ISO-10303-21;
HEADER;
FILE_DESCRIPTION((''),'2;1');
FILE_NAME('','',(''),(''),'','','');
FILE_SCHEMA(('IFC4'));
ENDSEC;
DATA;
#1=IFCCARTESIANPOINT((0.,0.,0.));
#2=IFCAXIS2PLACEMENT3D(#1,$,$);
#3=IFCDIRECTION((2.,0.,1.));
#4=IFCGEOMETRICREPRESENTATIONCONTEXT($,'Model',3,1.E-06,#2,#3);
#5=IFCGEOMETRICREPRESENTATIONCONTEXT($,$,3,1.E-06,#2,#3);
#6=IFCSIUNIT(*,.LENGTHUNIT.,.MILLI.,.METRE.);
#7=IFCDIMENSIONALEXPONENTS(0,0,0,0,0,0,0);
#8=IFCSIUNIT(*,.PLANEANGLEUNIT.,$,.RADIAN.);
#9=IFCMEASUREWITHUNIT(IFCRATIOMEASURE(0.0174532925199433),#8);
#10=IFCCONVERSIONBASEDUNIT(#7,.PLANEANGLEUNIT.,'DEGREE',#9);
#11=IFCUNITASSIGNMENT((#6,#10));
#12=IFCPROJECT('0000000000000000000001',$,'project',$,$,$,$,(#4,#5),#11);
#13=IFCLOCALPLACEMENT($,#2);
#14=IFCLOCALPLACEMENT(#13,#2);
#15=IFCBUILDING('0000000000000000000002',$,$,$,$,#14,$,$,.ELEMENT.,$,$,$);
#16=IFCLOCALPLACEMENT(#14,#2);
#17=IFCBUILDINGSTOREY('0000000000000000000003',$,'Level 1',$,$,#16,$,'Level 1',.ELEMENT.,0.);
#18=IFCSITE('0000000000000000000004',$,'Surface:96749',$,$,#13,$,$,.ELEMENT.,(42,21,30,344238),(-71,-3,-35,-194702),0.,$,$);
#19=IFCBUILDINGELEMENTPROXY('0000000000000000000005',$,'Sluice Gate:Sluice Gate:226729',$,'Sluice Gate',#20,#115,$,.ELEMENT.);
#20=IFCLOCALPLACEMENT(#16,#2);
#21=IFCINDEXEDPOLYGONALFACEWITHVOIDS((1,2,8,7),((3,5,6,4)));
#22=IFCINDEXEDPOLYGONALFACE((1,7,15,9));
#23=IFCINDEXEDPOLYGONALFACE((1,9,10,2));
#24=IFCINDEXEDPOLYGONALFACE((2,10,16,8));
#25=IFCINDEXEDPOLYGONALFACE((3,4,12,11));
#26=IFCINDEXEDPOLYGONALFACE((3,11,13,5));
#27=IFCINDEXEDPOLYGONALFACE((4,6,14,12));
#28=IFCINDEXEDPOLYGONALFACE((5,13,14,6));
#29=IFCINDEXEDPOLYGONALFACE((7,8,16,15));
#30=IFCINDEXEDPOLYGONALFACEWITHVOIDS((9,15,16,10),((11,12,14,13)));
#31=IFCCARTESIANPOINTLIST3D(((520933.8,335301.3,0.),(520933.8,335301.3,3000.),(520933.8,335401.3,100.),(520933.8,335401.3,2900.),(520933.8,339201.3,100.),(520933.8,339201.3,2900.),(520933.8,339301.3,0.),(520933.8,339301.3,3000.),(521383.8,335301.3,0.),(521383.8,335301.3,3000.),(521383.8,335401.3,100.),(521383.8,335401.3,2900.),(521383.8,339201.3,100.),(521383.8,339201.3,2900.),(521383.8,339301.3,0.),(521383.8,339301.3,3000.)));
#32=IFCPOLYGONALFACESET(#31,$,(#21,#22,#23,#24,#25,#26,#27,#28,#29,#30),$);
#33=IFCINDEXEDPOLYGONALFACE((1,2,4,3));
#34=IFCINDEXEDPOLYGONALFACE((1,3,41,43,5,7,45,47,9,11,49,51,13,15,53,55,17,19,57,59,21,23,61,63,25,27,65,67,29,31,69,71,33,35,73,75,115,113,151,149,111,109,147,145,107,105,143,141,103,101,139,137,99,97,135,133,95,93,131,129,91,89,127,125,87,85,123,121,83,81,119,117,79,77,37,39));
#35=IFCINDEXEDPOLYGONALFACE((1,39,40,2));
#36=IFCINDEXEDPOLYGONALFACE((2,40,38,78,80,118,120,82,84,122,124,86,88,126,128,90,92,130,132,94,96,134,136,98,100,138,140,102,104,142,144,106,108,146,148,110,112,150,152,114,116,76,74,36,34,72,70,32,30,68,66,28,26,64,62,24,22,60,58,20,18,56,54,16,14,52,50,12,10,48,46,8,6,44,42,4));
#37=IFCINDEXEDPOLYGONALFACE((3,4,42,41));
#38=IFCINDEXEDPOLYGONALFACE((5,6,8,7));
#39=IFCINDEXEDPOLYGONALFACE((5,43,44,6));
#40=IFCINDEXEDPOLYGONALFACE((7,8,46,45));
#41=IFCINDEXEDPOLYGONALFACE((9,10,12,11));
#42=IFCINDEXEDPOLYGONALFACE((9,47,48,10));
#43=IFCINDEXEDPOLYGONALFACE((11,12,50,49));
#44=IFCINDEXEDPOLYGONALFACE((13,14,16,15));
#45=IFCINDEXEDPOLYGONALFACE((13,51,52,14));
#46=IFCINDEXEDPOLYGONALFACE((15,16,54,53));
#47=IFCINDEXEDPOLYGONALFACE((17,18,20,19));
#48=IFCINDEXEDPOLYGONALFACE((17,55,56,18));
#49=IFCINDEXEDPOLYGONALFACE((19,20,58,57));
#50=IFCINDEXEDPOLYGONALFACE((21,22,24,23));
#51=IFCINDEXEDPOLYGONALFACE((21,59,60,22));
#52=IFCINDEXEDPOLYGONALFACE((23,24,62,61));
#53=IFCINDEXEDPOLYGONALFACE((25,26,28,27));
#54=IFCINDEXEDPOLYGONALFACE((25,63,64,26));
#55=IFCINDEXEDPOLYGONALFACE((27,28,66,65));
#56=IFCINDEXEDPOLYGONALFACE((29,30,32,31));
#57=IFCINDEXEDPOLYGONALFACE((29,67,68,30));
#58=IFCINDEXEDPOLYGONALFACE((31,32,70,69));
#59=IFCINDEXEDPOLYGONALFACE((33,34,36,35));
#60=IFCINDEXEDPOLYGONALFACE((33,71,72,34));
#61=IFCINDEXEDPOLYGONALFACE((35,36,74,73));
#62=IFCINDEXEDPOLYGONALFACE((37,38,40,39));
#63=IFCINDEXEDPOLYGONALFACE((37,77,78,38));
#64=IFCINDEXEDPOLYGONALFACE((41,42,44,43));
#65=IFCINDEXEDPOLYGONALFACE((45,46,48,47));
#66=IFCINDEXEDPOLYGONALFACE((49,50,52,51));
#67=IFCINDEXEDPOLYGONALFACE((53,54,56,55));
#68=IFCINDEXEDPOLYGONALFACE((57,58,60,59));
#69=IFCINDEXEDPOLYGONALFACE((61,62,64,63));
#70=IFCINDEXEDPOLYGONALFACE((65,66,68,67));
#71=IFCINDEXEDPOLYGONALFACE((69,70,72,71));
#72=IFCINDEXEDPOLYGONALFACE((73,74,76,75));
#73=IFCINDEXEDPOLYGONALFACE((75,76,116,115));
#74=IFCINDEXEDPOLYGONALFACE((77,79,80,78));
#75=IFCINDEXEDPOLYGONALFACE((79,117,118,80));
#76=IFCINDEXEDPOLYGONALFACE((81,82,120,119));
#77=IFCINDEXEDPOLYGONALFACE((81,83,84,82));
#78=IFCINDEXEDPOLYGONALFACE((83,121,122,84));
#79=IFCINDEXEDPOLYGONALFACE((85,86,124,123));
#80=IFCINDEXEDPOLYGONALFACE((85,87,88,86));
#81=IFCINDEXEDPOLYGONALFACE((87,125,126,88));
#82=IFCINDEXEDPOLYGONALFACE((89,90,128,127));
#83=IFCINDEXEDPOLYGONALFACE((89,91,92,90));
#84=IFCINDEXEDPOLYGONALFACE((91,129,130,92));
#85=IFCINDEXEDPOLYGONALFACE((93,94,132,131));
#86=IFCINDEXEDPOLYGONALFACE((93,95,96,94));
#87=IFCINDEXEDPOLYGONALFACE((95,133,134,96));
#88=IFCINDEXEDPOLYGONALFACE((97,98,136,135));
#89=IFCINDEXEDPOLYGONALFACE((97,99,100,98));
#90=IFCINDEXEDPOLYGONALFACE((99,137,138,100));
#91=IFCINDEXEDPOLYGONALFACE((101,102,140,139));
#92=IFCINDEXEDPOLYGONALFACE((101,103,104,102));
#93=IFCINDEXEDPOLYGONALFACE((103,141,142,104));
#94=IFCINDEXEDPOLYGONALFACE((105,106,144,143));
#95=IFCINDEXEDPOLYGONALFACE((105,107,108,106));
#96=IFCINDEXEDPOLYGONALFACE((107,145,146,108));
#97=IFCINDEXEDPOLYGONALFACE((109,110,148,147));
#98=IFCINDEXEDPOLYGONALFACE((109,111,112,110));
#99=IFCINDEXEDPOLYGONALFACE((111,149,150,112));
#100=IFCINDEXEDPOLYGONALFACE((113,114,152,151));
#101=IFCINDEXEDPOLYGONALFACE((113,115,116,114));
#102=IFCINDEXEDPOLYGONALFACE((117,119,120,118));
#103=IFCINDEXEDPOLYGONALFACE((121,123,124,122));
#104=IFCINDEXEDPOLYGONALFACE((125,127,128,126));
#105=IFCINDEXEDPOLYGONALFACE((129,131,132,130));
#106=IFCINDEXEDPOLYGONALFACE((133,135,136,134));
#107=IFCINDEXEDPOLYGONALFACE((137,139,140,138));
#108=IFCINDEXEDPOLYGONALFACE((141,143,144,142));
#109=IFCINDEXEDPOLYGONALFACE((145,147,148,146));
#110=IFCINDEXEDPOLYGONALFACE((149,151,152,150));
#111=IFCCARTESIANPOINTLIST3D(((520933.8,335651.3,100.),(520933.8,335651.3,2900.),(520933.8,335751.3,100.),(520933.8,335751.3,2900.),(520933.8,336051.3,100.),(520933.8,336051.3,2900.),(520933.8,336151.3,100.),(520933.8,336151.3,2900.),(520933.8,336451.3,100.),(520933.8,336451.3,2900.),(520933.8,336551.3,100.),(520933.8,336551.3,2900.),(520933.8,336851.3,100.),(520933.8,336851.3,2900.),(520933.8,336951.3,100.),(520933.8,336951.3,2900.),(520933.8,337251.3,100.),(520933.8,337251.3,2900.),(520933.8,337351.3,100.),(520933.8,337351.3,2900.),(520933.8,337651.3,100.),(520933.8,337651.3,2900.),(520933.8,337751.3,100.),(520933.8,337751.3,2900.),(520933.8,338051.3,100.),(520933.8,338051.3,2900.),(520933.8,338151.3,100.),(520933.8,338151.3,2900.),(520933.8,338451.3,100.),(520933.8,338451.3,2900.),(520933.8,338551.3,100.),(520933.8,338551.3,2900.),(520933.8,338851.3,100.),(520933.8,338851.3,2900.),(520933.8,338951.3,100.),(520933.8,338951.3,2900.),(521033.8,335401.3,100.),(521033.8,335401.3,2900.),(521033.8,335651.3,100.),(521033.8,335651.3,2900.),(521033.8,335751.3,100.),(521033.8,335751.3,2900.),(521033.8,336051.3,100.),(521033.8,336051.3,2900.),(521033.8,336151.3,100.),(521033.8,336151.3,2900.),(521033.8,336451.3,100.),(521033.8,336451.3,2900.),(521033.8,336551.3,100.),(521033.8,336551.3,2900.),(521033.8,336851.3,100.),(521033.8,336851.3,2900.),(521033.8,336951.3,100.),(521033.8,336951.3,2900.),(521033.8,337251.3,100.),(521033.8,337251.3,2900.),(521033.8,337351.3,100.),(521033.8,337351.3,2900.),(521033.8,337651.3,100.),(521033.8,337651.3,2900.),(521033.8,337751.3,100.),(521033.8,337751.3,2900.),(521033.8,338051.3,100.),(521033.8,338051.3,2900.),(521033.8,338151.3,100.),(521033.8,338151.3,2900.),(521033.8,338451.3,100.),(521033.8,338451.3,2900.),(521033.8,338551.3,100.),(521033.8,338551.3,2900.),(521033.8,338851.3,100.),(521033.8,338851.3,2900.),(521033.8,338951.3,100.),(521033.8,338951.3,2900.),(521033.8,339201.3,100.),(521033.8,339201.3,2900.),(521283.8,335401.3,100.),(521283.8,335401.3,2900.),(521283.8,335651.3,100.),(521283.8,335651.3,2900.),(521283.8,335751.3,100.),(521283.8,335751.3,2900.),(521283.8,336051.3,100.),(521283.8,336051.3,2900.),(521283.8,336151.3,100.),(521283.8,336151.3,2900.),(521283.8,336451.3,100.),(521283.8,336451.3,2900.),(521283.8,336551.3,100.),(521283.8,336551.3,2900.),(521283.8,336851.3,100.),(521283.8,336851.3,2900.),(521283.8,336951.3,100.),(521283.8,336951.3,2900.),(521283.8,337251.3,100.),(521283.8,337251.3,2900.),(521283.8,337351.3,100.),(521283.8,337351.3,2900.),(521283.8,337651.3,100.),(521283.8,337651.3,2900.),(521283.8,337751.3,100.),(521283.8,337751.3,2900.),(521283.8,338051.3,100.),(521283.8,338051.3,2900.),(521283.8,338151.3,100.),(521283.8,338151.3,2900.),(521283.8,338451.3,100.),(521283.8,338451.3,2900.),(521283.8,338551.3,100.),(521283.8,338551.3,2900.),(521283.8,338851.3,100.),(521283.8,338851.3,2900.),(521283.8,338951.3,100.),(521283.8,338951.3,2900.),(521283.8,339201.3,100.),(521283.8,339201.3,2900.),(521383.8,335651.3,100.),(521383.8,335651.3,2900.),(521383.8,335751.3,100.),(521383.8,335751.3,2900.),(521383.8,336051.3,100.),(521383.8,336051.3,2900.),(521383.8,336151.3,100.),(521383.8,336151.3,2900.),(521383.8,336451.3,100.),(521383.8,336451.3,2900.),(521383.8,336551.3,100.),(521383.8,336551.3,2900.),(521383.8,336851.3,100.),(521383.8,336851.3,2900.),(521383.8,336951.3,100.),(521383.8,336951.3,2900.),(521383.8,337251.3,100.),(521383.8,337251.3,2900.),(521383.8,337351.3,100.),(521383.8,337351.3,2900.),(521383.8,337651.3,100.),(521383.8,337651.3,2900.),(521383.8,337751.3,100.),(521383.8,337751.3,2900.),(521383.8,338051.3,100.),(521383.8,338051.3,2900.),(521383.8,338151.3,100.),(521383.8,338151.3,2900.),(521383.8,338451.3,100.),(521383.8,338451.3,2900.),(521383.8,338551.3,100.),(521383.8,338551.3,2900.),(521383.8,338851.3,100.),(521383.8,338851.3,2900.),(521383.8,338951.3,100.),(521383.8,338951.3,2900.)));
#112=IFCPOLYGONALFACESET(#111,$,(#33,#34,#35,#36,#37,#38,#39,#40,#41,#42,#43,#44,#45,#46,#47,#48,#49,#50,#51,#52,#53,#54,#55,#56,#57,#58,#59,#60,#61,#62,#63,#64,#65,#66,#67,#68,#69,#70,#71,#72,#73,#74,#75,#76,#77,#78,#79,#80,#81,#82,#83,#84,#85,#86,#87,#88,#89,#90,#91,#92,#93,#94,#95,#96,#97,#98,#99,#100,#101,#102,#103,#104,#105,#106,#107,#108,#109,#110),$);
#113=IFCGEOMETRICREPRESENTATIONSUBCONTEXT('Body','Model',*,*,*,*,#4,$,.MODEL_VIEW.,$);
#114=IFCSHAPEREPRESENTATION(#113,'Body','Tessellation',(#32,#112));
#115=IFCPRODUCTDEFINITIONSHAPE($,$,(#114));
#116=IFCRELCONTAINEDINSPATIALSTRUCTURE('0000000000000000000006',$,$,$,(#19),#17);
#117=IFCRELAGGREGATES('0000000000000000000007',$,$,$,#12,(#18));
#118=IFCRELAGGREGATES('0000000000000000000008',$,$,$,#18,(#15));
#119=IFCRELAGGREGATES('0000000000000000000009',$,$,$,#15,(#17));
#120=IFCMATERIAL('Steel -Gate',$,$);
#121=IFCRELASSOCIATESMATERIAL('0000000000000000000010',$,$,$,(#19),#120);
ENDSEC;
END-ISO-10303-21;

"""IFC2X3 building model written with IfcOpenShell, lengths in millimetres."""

from ifc_helpers import new_model, entity, si_unit, converted_unit, direction, frame, origin, place, context, subcontext, project, spatial, polyline, outline, extrude, source, transform, mapped, material, element, save


model = new_model("IFC2X3")

# Units and contexts
model_context = context("Model", 3, precision=1e-06, world=origin(), true_north=direction((2.0, 0.0, 1.0)))
context_of_model = context(None, 3, precision=1e-06, world=origin(), true_north=direction((2.0, 0.0, 1.0)))
body_context = subcontext(model_context, "Body", "Model", "MODEL_VIEW")
ifc_project = project(units=[si_unit("LENGTHUNIT", "METRE", prefix="MILLI"), converted_unit("PLANEANGLEUNIT", "DEGREE", entity("IfcRatioMeasure", 0.0174532925199433), si_unit("PLANEANGLEUNIT", "RADIAN"), dimensions=[0, 0, 0, 0, 0, 0, 0])], contexts=[model_context, context_of_model])

# Site, building, storey
site_placement = place(None, origin())
site = spatial("IfcSite", under=ifc_project, at=site_placement, Name="Surface:96749", CompositionType="ELEMENT", RefLatitude=(42, 21, 30, 344238), RefLongitude=(-71, -3, -35, -194702), RefElevation=0.0)
building_placement = place(site_placement, origin())
building = spatial("IfcBuilding", under=site, at=building_placement, CompositionType="ELEMENT")
storey_placement = place(building_placement, origin())
storey = spatial("IfcBuildingStorey", under=building, at=storey_placement, Name="Level 1", LongName="Level 1", CompositionType="ELEMENT", Elevation=0.0)

# Building element proxy
ifc_material = material(Name="Steel -Gate")
shared_shape_1 = source(origin(), body_context, "Body", "SweptSolid", [
    extrude(outline(polyline([(-1500.0, -2000.0), (1500.0, -2000.0), (1500.0, 2000.0), (-1500.0, 2000.0), (-1500.0, -2000.0)]), holes=[polyline([(1400.0, -1900.0), (-1400.0, -1900.0), (-1400.0, 1900.0), (1400.0, 1900.0), (1400.0, -1900.0)])]), frame((0.0, -225.0, 1500.0), z_axis=(0.0, 1.0, 0.0), x_axis=(0.0, 0.0, -1.0)), (0.0, 0.0, 1.0), 450.0),
    extrude(outline(polyline([(1650.0, -125.0), (1900.0, -125.0), (1900.0, 125.0), (1650.0, 125.0), (1650.0, 225.0), (1550.0, 225.0), (1550.0, 125.0), (1250.0, 125.0), (1250.0, 225.0), (1150.0, 225.0), (1150.0, 125.0), (850.0, 125.0), (850.0, 225.0), (750.0, 225.0), (750.0, 125.0), (450.0, 125.0), (450.0, 225.0), (350.0, 225.0), (350.0, 125.0), (50.0, 125.0), (50.0, 225.0), (-50.0, 225.0), (-50.0, 125.0), (-350.0, 125.0), (-350.0, 225.0), (-450.0, 225.0), (-450.0, 125.0), (-750.0, 125.0), (-750.0, 225.0), (-850.0, 225.0), (-850.0, 125.0), (-1150.0, 125.0), (-1150.0, 225.0), (-1250.0, 225.0), (-1250.0, 125.0), (-1550.0, 125.0), (-1550.0, 225.0), (-1650.0, 225.0), (-1650.0, 125.0), (-1900.0, 125.0), (-1900.0, -125.0), (-1650.0, -125.0), (-1650.0, -225.0), (-1550.0, -225.0), (-1550.0, -125.0), (-1250.0, -125.0), (-1250.0, -225.0), (-1150.0, -225.0), (-1150.0, -125.0), (-850.0, -125.0), (-850.0, -225.0), (-750.0, -225.0), (-750.0, -125.0), (-450.0, -125.0), (-450.0, -225.0), (-350.0, -225.0), (-350.0, -125.0), (-50.0, -125.0), (-50.0, -225.0), (50.0, -225.0), (50.0, -125.0), (350.0, -125.0), (350.0, -225.0), (450.0, -225.0), (450.0, -125.0), (750.0, -125.0), (750.0, -225.0), (850.0, -225.0), (850.0, -125.0), (1150.0, -125.0), (1150.0, -225.0), (1250.0, -225.0), (1250.0, -125.0), (1550.0, -125.0), (1550.0, -225.0), (1650.0, -225.0), (1650.0, -125.0)])), frame((0.0, 0.0, 100.0), z_axis=(0.0, 0.0, 1.0), x_axis=(-1.0, 0.0, 0.0)), (0.0, 0.0, 1.0), 2800.0),
])
for number, where, z_axis, x_axis, name in (
    (1, (521158.8, 337301.3, 0.0), (0.0, 0.0, 1.0), (0.0, 1.0, 0.0), "Sluice Gate:Sluice Gate:226729"),
):
    element("IfcBuildingElementProxy", number, at=place(storey_placement, frame(where, z_axis=z_axis, x_axis=x_axis)), inside=storey, material=ifc_material, Name=name, ObjectType="Sluice Gate", CompositionType="ELEMENT", context=body_context, shape_type="MappedRepresentation", body=[
        mapped(shared_shape_1, transform((0.0, 0.0, 0.0), scale=1.0)),
    ])

save(model, "model.ifc")
